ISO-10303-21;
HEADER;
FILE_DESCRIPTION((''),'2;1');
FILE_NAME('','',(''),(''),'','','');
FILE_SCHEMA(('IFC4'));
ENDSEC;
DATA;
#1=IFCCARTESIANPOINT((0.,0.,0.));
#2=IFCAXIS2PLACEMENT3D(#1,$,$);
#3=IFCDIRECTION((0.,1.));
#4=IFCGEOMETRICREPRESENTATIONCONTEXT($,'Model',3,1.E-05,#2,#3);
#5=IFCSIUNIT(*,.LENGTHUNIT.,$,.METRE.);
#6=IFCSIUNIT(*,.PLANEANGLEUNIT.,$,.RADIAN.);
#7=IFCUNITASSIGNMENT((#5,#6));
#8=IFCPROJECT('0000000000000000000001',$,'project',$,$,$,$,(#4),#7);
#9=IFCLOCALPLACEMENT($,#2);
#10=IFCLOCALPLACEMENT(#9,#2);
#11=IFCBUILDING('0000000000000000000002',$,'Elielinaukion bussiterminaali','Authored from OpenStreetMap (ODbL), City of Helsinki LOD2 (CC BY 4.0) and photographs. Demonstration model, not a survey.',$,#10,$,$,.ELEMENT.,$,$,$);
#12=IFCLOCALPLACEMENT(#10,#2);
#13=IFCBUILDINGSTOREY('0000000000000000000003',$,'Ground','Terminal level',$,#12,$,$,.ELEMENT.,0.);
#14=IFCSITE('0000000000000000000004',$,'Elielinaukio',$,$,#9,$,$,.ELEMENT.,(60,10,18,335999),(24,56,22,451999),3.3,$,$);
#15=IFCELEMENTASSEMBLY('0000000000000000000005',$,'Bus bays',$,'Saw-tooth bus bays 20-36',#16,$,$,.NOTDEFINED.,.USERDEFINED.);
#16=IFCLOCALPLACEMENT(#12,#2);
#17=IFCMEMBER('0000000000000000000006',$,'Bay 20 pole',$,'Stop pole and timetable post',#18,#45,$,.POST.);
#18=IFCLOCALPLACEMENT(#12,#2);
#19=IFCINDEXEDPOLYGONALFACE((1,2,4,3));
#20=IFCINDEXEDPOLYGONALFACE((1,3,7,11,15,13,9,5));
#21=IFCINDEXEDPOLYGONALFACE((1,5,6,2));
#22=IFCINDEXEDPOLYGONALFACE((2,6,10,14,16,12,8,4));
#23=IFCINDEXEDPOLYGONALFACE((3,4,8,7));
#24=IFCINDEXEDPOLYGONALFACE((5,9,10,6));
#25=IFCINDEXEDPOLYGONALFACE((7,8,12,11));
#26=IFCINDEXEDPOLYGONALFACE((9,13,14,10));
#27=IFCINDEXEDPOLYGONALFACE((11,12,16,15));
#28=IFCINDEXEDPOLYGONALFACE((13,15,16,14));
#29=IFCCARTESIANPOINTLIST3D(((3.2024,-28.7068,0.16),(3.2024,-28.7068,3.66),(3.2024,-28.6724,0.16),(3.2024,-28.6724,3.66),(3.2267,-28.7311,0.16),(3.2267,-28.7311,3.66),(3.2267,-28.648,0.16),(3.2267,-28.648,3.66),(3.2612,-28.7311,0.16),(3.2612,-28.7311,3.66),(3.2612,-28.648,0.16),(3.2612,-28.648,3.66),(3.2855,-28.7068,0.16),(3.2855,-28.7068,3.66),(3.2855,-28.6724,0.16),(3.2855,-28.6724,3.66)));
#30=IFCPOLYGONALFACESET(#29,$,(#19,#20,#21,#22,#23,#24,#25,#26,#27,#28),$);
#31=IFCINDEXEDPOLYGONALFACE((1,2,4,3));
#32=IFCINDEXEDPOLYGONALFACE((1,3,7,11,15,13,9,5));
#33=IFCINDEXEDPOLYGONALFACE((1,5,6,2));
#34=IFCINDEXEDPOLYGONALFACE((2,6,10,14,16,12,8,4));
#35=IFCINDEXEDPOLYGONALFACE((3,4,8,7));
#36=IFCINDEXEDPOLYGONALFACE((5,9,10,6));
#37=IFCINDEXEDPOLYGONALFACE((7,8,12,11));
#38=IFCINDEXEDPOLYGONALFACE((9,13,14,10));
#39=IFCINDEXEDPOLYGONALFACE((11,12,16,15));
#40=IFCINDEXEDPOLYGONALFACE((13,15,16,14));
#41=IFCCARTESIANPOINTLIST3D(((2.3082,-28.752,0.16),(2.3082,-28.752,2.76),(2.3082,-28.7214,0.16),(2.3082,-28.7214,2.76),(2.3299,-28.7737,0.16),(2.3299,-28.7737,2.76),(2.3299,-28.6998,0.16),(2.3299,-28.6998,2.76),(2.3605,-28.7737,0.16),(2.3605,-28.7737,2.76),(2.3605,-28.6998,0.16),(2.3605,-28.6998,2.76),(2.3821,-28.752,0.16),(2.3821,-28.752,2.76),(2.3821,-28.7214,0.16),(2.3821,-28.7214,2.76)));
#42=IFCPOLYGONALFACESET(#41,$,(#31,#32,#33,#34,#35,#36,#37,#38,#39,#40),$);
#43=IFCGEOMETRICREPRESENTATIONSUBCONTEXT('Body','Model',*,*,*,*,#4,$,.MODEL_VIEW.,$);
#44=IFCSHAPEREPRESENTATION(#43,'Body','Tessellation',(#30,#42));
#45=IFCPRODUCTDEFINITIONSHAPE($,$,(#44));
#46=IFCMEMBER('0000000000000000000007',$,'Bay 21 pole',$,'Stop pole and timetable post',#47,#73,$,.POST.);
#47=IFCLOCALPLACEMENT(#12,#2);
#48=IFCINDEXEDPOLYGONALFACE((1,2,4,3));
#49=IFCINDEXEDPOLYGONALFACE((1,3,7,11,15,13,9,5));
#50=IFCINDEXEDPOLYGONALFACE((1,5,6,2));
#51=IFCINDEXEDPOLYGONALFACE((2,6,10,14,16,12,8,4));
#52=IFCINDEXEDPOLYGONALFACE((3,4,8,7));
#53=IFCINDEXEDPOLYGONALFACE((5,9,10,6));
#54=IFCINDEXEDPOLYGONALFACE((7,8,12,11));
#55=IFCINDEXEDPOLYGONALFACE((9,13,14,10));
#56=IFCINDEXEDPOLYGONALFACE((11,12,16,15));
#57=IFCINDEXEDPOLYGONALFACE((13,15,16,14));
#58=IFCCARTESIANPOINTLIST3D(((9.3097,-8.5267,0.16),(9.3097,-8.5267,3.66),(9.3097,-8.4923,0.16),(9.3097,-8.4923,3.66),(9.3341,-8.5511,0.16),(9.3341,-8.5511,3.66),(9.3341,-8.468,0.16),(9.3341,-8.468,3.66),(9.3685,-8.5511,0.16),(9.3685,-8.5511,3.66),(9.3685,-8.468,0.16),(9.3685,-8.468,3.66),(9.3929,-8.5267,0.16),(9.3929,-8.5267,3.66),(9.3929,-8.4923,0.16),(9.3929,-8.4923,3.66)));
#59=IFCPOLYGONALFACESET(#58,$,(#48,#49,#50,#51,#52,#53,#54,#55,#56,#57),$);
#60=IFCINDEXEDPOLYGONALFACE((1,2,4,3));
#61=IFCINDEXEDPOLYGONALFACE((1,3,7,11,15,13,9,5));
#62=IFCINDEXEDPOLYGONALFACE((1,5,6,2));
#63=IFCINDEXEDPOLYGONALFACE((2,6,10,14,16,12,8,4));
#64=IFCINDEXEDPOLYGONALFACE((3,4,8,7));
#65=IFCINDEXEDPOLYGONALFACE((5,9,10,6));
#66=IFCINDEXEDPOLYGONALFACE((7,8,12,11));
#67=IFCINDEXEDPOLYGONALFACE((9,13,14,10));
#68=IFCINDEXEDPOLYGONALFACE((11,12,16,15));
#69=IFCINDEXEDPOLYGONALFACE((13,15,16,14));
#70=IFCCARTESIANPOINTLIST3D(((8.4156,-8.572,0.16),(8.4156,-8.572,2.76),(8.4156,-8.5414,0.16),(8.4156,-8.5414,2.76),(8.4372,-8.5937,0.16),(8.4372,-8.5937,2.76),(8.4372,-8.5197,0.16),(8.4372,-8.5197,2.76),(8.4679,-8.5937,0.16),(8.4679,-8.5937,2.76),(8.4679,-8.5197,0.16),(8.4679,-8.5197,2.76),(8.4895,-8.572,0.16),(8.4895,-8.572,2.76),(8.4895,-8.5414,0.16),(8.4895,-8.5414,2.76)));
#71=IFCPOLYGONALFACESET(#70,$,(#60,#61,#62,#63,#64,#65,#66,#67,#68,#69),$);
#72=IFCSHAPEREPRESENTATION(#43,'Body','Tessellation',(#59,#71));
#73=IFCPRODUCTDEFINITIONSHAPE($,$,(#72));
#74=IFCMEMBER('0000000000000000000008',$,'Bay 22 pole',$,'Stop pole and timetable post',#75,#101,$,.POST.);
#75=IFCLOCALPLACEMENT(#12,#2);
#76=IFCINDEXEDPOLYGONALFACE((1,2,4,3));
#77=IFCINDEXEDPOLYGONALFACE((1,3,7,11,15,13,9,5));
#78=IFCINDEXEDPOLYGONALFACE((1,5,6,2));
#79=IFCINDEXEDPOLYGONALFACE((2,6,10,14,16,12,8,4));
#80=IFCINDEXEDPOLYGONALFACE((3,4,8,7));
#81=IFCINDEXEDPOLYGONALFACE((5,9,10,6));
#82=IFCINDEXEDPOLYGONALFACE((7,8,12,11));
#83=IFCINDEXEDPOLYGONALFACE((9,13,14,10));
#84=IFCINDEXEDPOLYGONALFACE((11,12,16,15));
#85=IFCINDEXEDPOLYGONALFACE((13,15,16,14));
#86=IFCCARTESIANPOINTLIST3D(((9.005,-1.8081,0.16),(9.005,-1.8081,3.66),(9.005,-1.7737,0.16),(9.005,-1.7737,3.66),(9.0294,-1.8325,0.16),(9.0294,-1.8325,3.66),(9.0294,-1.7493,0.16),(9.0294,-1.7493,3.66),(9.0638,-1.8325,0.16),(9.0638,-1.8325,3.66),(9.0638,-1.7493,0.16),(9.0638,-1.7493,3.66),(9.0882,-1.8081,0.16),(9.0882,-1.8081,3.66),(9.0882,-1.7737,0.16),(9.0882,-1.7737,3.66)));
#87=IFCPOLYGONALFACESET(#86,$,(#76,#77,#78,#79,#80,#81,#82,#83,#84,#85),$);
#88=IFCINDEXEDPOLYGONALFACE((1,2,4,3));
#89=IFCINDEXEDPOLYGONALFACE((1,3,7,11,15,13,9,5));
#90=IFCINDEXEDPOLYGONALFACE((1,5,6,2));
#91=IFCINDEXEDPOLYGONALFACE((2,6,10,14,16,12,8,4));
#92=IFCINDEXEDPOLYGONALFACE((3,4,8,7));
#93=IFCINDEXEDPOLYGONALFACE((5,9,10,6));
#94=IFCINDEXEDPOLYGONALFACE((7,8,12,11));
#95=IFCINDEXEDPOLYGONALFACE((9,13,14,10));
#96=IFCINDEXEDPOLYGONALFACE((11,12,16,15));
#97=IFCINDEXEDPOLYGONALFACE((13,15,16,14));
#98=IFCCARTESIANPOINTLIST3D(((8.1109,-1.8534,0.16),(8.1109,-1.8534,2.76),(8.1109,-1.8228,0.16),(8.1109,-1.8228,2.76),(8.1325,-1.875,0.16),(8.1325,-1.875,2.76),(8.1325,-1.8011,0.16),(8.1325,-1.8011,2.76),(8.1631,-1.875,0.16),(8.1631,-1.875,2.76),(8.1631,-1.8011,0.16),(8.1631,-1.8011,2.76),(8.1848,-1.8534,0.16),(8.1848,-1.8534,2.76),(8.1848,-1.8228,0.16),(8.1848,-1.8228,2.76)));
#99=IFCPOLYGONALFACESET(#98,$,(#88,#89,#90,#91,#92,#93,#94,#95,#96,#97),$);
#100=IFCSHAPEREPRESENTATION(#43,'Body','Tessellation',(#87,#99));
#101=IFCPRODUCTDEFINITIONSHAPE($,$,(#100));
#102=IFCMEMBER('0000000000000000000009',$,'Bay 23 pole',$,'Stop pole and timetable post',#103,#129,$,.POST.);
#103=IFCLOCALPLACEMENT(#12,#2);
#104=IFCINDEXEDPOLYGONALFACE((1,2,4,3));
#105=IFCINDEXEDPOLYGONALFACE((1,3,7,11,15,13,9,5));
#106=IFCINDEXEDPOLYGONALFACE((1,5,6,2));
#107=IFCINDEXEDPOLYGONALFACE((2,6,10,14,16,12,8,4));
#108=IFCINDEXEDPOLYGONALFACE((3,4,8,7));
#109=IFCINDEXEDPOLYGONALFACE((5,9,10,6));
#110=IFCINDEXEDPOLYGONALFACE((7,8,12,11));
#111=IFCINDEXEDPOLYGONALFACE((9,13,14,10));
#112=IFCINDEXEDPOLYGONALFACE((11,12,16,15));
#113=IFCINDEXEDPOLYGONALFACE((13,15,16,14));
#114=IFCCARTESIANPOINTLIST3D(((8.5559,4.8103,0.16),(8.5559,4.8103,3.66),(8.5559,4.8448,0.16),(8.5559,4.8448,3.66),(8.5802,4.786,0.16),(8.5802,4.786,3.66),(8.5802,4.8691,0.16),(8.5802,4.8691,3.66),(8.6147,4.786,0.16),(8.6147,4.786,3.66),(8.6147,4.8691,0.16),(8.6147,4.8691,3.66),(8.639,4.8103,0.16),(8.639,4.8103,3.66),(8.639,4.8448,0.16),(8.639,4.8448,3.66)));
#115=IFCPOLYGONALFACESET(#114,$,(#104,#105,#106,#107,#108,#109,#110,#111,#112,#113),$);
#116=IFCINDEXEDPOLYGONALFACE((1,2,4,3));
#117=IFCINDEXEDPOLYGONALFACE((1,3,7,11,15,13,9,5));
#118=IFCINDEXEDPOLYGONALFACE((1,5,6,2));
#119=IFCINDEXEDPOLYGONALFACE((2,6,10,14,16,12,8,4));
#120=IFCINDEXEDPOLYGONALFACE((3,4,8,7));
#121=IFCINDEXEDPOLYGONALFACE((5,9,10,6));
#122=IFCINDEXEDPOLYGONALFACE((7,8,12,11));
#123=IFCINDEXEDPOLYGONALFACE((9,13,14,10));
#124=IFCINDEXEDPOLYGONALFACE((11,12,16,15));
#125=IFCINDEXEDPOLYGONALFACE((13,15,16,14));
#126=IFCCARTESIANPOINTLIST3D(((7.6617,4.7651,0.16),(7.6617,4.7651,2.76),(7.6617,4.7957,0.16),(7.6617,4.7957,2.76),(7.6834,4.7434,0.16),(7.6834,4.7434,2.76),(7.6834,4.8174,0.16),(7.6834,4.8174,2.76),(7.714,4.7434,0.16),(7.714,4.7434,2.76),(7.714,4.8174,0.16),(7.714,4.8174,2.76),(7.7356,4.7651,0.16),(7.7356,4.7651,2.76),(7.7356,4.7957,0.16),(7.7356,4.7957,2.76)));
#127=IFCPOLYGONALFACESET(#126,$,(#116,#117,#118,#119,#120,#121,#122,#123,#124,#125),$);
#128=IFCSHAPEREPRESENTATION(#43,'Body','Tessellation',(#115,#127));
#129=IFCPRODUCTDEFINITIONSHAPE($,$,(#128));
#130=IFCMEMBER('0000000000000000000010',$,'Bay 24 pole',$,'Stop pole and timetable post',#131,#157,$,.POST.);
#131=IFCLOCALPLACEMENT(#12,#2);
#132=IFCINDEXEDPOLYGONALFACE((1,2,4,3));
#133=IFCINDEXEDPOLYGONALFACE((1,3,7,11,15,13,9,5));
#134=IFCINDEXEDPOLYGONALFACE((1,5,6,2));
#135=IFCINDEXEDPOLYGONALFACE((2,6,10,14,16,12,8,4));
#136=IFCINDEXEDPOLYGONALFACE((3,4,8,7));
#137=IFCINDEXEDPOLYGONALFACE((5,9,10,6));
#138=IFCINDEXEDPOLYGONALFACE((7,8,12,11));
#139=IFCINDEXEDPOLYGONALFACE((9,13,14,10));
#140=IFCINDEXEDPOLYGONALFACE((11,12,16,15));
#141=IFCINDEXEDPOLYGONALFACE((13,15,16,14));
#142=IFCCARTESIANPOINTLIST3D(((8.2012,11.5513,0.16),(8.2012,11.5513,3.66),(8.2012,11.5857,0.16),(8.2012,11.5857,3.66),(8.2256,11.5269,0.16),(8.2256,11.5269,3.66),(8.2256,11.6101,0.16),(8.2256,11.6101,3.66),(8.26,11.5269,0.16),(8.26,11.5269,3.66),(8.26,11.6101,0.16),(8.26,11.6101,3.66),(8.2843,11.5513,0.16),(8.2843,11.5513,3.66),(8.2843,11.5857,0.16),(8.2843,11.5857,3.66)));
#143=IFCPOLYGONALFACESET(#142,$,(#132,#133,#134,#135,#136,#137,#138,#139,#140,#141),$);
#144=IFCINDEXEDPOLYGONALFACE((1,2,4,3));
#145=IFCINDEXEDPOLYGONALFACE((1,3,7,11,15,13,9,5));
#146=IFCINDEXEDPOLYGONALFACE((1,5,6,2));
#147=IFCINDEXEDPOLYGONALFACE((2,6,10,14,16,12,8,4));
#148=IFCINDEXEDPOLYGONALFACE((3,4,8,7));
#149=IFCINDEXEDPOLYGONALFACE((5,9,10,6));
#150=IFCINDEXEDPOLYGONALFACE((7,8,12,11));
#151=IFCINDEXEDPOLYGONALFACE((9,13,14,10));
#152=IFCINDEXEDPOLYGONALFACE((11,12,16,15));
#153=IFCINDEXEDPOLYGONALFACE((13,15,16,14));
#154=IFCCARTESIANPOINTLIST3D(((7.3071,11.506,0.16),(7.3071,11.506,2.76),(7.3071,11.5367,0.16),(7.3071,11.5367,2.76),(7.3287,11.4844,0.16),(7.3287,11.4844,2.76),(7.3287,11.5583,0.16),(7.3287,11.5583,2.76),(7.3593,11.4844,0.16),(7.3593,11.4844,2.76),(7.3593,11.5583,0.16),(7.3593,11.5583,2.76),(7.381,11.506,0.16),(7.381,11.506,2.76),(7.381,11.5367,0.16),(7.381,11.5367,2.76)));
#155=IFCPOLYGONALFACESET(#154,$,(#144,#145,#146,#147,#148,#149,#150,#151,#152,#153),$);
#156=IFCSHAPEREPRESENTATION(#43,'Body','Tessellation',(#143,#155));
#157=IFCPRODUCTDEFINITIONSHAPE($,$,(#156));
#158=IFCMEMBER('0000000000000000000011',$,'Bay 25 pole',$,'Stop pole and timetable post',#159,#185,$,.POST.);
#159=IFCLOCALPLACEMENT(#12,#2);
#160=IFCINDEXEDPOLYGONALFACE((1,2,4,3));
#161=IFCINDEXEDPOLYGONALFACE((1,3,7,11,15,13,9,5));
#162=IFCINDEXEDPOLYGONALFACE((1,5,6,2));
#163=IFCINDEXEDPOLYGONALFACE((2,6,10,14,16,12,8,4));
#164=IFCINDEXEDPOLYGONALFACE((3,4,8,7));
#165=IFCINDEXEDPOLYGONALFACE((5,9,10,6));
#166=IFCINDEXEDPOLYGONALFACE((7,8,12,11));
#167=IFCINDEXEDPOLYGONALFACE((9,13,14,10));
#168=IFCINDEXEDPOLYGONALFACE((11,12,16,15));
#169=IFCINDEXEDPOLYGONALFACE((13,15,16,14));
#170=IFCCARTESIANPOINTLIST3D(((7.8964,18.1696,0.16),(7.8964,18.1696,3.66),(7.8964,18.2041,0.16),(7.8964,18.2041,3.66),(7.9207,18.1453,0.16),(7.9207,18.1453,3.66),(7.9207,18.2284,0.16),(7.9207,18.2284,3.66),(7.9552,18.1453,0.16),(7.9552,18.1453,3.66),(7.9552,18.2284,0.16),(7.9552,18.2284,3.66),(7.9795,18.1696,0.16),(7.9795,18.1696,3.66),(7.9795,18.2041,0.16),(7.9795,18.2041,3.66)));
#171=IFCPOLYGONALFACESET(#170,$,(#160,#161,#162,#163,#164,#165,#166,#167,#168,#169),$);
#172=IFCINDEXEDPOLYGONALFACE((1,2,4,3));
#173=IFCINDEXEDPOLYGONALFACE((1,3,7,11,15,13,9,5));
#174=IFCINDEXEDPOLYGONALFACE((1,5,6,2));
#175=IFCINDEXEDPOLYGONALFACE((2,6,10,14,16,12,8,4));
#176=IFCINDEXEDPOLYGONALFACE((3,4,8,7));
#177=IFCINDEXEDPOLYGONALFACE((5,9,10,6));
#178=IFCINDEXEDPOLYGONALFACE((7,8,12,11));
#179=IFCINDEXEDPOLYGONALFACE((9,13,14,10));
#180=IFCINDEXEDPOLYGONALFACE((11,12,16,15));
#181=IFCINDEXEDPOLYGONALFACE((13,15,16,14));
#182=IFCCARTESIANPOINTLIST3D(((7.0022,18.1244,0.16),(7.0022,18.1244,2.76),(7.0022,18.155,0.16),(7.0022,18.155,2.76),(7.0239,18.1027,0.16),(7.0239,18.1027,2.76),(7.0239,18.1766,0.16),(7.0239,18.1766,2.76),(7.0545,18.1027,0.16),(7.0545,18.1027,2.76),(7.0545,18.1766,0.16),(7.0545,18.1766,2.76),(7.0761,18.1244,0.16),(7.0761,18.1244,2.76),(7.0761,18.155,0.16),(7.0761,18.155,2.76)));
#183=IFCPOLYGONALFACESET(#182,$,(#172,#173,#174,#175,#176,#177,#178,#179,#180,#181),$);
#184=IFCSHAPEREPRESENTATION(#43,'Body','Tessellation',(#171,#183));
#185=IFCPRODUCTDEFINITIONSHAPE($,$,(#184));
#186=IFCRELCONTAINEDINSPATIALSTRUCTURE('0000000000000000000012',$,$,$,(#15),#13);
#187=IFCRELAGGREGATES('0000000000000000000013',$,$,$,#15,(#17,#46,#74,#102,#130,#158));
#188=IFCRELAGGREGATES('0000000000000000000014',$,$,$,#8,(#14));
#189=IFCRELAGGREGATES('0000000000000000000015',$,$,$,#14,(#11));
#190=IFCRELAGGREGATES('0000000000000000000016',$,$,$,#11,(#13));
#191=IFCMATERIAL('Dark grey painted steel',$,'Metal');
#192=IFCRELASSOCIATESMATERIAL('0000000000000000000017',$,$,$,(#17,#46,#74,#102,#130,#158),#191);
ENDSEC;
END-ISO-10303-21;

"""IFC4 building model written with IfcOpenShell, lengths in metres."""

from ifc_helpers import new_model, si_unit, direction, frame, origin, place, context, subcontext, project, spatial, polyline, outline, extrude, material, element, aggregate, save


model = new_model("IFC4")

# Units and contexts
model_context = context("Model", 3, precision=1e-05, world=origin(), true_north=direction((0.0, 1.0)))
body_context = subcontext(model_context, "Body", "Model", "MODEL_VIEW")
ifc_project = project(units=[si_unit("LENGTHUNIT", "METRE"), si_unit("PLANEANGLEUNIT", "RADIAN")], contexts=[model_context])

# Site, building, storey
site_placement = place(None, origin())
site = spatial("IfcSite", under=ifc_project, at=site_placement, Name="Elielinaukio", CompositionType="ELEMENT", RefLatitude=(60, 10, 18, 335999), RefLongitude=(24, 56, 22, 451999), RefElevation=3.3)
building_placement = place(site_placement, origin())
building = spatial("IfcBuilding", under=site, at=building_placement, Name="Elielinaukion bussiterminaali", Description="Authored from OpenStreetMap (ODbL), City of Helsinki LOD2 (CC BY 4.0) and photographs. Demonstration model, not a survey.", CompositionType="ELEMENT")
storey_placement = place(building_placement, origin())
storey = spatial("IfcBuildingStorey", under=building, at=storey_placement, Name="Ground", Description="Terminal level", CompositionType="ELEMENT", Elevation=0.0)

# Element assembly, members
assembly_placement = place(building_placement, origin())
assembly = element("IfcElementAssembly", 1, at=assembly_placement, inside=storey, Name="Bus bays", ObjectType="Saw-tooth bus bays 20-36", AssemblyPlace="NOTDEFINED", PredefinedType="USERDEFINED")
ifc_material_1 = material(Name="Dark grey painted steel", Category="Metal")
member_1_placement = place(building_placement, origin())
member_1 = element("IfcMember", 2, at=member_1_placement, material=ifc_material_1, Name="Bay 20 pole", ObjectType="Stop pole and timetable post", PredefinedType="POST", context=body_context, shape_type="SweptSolid", body=[
    extrude(outline(polyline([(3.2855, -28.6724), (3.2612, -28.648), (3.2267, -28.648), (3.2024, -28.6724), (3.2024, -28.7068), (3.2267, -28.7311), (3.2612, -28.7311), (3.2855, -28.7068), (3.2855, -28.6724)])), frame((0.0, 0.0, 0.16)), (0.0, 0.0, 1.0), 3.5),
    extrude(outline(polyline([(2.3821, -28.7214), (2.3605, -28.6998), (2.3299, -28.6998), (2.3082, -28.7214), (2.3082, -28.752), (2.3299, -28.7737), (2.3605, -28.7737), (2.3821, -28.752), (2.3821, -28.7214)])), frame((0.0, 0.0, 0.16)), (0.0, 0.0, 1.0), 2.6),
])
member_2_placement = place(building_placement, origin())
member_2 = element("IfcMember", 3, at=member_2_placement, material=ifc_material_1, Name="Bay 21 pole", ObjectType="Stop pole and timetable post", PredefinedType="POST", context=body_context, shape_type="SweptSolid", body=[
    extrude(outline(polyline([(9.3929, -8.4923), (9.3685, -8.468), (9.3341, -8.468), (9.3097, -8.4923), (9.3097, -8.5267), (9.3341, -8.5511), (9.3685, -8.5511), (9.3929, -8.5267), (9.3929, -8.4923)])), frame((0.0, 0.0, 0.16)), (0.0, 0.0, 1.0), 3.5),
    extrude(outline(polyline([(8.4895, -8.5414), (8.4679, -8.5197), (8.4372, -8.5197), (8.4156, -8.5414), (8.4156, -8.572), (8.4372, -8.5937), (8.4679, -8.5937), (8.4895, -8.572), (8.4895, -8.5414)])), frame((0.0, 0.0, 0.16)), (0.0, 0.0, 1.0), 2.6),
])
member_3_placement = place(building_placement, origin())
member_3 = element("IfcMember", 4, at=member_3_placement, material=ifc_material_1, Name="Bay 22 pole", ObjectType="Stop pole and timetable post", PredefinedType="POST", context=body_context, shape_type="SweptSolid", body=[
    extrude(outline(polyline([(9.0882, -1.7737), (9.0638, -1.7493), (9.0294, -1.7493), (9.005, -1.7737), (9.005, -1.8081), (9.0294, -1.8325), (9.0638, -1.8325), (9.0882, -1.8081), (9.0882, -1.7737)])), frame((0.0, 0.0, 0.16)), (0.0, 0.0, 1.0), 3.5),
    extrude(outline(polyline([(8.1848, -1.8228), (8.1631, -1.8011), (8.1325, -1.8011), (8.1109, -1.8228), (8.1109, -1.8534), (8.1325, -1.875), (8.1631, -1.875), (8.1848, -1.8534), (8.1848, -1.8228)])), frame((0.0, 0.0, 0.16)), (0.0, 0.0, 1.0), 2.6),
])
member_4_placement = place(building_placement, origin())
member_4 = element("IfcMember", 5, at=member_4_placement, material=ifc_material_1, Name="Bay 23 pole", ObjectType="Stop pole and timetable post", PredefinedType="POST", context=body_context, shape_type="SweptSolid", body=[
    extrude(outline(polyline([(8.639, 4.8448), (8.6147, 4.8691), (8.5802, 4.8691), (8.5559, 4.8448), (8.5559, 4.8103), (8.5802, 4.786), (8.6147, 4.786), (8.639, 4.8103), (8.639, 4.8448)])), frame((0.0, 0.0, 0.16)), (0.0, 0.0, 1.0), 3.5),
    extrude(outline(polyline([(7.7356, 4.7957), (7.714, 4.8174), (7.6834, 4.8174), (7.6617, 4.7957), (7.6617, 4.7651), (7.6834, 4.7434), (7.714, 4.7434), (7.7356, 4.7651), (7.7356, 4.7957)])), frame((0.0, 0.0, 0.16)), (0.0, 0.0, 1.0), 2.6),
])
member_5_placement = place(building_placement, origin())
member_5 = element("IfcMember", 6, at=member_5_placement, material=ifc_material_1, Name="Bay 24 pole", ObjectType="Stop pole and timetable post", PredefinedType="POST", context=body_context, shape_type="SweptSolid", body=[
    extrude(outline(polyline([(8.2843, 11.5857), (8.26, 11.6101), (8.2256, 11.6101), (8.2012, 11.5857), (8.2012, 11.5513), (8.2256, 11.5269), (8.26, 11.5269), (8.2843, 11.5513), (8.2843, 11.5857)])), frame((0.0, 0.0, 0.16)), (0.0, 0.0, 1.0), 3.5),
    extrude(outline(polyline([(7.381, 11.5367), (7.3593, 11.5583), (7.3287, 11.5583), (7.3071, 11.5367), (7.3071, 11.506), (7.3287, 11.4844), (7.3593, 11.4844), (7.381, 11.506), (7.381, 11.5367)])), frame((0.0, 0.0, 0.16)), (0.0, 0.0, 1.0), 2.6),
])
member_6_placement = place(building_placement, origin())
member_6 = element("IfcMember", 7, at=member_6_placement, material=ifc_material_1, Name="Bay 25 pole", ObjectType="Stop pole and timetable post", PredefinedType="POST", context=body_context, shape_type="SweptSolid", body=[
    extrude(outline(polyline([(7.9795, 18.2041), (7.9552, 18.2284), (7.9207, 18.2284), (7.8964, 18.2041), (7.8964, 18.1696), (7.9207, 18.1453), (7.9552, 18.1453), (7.9795, 18.1696), (7.9795, 18.2041)])), frame((0.0, 0.0, 0.16)), (0.0, 0.0, 1.0), 3.5),
    extrude(outline(polyline([(7.0761, 18.155), (7.0545, 18.1766), (7.0239, 18.1766), (7.0022, 18.155), (7.0022, 18.1244), (7.0239, 18.1027), (7.0545, 18.1027), (7.0761, 18.1244), (7.0761, 18.155)])), frame((0.0, 0.0, 0.16)), (0.0, 0.0, 1.0), 2.6),
])
aggregate(assembly, [member_1, member_2, member_3, member_4, member_5, member_6])

save(model, "model.ifc")
